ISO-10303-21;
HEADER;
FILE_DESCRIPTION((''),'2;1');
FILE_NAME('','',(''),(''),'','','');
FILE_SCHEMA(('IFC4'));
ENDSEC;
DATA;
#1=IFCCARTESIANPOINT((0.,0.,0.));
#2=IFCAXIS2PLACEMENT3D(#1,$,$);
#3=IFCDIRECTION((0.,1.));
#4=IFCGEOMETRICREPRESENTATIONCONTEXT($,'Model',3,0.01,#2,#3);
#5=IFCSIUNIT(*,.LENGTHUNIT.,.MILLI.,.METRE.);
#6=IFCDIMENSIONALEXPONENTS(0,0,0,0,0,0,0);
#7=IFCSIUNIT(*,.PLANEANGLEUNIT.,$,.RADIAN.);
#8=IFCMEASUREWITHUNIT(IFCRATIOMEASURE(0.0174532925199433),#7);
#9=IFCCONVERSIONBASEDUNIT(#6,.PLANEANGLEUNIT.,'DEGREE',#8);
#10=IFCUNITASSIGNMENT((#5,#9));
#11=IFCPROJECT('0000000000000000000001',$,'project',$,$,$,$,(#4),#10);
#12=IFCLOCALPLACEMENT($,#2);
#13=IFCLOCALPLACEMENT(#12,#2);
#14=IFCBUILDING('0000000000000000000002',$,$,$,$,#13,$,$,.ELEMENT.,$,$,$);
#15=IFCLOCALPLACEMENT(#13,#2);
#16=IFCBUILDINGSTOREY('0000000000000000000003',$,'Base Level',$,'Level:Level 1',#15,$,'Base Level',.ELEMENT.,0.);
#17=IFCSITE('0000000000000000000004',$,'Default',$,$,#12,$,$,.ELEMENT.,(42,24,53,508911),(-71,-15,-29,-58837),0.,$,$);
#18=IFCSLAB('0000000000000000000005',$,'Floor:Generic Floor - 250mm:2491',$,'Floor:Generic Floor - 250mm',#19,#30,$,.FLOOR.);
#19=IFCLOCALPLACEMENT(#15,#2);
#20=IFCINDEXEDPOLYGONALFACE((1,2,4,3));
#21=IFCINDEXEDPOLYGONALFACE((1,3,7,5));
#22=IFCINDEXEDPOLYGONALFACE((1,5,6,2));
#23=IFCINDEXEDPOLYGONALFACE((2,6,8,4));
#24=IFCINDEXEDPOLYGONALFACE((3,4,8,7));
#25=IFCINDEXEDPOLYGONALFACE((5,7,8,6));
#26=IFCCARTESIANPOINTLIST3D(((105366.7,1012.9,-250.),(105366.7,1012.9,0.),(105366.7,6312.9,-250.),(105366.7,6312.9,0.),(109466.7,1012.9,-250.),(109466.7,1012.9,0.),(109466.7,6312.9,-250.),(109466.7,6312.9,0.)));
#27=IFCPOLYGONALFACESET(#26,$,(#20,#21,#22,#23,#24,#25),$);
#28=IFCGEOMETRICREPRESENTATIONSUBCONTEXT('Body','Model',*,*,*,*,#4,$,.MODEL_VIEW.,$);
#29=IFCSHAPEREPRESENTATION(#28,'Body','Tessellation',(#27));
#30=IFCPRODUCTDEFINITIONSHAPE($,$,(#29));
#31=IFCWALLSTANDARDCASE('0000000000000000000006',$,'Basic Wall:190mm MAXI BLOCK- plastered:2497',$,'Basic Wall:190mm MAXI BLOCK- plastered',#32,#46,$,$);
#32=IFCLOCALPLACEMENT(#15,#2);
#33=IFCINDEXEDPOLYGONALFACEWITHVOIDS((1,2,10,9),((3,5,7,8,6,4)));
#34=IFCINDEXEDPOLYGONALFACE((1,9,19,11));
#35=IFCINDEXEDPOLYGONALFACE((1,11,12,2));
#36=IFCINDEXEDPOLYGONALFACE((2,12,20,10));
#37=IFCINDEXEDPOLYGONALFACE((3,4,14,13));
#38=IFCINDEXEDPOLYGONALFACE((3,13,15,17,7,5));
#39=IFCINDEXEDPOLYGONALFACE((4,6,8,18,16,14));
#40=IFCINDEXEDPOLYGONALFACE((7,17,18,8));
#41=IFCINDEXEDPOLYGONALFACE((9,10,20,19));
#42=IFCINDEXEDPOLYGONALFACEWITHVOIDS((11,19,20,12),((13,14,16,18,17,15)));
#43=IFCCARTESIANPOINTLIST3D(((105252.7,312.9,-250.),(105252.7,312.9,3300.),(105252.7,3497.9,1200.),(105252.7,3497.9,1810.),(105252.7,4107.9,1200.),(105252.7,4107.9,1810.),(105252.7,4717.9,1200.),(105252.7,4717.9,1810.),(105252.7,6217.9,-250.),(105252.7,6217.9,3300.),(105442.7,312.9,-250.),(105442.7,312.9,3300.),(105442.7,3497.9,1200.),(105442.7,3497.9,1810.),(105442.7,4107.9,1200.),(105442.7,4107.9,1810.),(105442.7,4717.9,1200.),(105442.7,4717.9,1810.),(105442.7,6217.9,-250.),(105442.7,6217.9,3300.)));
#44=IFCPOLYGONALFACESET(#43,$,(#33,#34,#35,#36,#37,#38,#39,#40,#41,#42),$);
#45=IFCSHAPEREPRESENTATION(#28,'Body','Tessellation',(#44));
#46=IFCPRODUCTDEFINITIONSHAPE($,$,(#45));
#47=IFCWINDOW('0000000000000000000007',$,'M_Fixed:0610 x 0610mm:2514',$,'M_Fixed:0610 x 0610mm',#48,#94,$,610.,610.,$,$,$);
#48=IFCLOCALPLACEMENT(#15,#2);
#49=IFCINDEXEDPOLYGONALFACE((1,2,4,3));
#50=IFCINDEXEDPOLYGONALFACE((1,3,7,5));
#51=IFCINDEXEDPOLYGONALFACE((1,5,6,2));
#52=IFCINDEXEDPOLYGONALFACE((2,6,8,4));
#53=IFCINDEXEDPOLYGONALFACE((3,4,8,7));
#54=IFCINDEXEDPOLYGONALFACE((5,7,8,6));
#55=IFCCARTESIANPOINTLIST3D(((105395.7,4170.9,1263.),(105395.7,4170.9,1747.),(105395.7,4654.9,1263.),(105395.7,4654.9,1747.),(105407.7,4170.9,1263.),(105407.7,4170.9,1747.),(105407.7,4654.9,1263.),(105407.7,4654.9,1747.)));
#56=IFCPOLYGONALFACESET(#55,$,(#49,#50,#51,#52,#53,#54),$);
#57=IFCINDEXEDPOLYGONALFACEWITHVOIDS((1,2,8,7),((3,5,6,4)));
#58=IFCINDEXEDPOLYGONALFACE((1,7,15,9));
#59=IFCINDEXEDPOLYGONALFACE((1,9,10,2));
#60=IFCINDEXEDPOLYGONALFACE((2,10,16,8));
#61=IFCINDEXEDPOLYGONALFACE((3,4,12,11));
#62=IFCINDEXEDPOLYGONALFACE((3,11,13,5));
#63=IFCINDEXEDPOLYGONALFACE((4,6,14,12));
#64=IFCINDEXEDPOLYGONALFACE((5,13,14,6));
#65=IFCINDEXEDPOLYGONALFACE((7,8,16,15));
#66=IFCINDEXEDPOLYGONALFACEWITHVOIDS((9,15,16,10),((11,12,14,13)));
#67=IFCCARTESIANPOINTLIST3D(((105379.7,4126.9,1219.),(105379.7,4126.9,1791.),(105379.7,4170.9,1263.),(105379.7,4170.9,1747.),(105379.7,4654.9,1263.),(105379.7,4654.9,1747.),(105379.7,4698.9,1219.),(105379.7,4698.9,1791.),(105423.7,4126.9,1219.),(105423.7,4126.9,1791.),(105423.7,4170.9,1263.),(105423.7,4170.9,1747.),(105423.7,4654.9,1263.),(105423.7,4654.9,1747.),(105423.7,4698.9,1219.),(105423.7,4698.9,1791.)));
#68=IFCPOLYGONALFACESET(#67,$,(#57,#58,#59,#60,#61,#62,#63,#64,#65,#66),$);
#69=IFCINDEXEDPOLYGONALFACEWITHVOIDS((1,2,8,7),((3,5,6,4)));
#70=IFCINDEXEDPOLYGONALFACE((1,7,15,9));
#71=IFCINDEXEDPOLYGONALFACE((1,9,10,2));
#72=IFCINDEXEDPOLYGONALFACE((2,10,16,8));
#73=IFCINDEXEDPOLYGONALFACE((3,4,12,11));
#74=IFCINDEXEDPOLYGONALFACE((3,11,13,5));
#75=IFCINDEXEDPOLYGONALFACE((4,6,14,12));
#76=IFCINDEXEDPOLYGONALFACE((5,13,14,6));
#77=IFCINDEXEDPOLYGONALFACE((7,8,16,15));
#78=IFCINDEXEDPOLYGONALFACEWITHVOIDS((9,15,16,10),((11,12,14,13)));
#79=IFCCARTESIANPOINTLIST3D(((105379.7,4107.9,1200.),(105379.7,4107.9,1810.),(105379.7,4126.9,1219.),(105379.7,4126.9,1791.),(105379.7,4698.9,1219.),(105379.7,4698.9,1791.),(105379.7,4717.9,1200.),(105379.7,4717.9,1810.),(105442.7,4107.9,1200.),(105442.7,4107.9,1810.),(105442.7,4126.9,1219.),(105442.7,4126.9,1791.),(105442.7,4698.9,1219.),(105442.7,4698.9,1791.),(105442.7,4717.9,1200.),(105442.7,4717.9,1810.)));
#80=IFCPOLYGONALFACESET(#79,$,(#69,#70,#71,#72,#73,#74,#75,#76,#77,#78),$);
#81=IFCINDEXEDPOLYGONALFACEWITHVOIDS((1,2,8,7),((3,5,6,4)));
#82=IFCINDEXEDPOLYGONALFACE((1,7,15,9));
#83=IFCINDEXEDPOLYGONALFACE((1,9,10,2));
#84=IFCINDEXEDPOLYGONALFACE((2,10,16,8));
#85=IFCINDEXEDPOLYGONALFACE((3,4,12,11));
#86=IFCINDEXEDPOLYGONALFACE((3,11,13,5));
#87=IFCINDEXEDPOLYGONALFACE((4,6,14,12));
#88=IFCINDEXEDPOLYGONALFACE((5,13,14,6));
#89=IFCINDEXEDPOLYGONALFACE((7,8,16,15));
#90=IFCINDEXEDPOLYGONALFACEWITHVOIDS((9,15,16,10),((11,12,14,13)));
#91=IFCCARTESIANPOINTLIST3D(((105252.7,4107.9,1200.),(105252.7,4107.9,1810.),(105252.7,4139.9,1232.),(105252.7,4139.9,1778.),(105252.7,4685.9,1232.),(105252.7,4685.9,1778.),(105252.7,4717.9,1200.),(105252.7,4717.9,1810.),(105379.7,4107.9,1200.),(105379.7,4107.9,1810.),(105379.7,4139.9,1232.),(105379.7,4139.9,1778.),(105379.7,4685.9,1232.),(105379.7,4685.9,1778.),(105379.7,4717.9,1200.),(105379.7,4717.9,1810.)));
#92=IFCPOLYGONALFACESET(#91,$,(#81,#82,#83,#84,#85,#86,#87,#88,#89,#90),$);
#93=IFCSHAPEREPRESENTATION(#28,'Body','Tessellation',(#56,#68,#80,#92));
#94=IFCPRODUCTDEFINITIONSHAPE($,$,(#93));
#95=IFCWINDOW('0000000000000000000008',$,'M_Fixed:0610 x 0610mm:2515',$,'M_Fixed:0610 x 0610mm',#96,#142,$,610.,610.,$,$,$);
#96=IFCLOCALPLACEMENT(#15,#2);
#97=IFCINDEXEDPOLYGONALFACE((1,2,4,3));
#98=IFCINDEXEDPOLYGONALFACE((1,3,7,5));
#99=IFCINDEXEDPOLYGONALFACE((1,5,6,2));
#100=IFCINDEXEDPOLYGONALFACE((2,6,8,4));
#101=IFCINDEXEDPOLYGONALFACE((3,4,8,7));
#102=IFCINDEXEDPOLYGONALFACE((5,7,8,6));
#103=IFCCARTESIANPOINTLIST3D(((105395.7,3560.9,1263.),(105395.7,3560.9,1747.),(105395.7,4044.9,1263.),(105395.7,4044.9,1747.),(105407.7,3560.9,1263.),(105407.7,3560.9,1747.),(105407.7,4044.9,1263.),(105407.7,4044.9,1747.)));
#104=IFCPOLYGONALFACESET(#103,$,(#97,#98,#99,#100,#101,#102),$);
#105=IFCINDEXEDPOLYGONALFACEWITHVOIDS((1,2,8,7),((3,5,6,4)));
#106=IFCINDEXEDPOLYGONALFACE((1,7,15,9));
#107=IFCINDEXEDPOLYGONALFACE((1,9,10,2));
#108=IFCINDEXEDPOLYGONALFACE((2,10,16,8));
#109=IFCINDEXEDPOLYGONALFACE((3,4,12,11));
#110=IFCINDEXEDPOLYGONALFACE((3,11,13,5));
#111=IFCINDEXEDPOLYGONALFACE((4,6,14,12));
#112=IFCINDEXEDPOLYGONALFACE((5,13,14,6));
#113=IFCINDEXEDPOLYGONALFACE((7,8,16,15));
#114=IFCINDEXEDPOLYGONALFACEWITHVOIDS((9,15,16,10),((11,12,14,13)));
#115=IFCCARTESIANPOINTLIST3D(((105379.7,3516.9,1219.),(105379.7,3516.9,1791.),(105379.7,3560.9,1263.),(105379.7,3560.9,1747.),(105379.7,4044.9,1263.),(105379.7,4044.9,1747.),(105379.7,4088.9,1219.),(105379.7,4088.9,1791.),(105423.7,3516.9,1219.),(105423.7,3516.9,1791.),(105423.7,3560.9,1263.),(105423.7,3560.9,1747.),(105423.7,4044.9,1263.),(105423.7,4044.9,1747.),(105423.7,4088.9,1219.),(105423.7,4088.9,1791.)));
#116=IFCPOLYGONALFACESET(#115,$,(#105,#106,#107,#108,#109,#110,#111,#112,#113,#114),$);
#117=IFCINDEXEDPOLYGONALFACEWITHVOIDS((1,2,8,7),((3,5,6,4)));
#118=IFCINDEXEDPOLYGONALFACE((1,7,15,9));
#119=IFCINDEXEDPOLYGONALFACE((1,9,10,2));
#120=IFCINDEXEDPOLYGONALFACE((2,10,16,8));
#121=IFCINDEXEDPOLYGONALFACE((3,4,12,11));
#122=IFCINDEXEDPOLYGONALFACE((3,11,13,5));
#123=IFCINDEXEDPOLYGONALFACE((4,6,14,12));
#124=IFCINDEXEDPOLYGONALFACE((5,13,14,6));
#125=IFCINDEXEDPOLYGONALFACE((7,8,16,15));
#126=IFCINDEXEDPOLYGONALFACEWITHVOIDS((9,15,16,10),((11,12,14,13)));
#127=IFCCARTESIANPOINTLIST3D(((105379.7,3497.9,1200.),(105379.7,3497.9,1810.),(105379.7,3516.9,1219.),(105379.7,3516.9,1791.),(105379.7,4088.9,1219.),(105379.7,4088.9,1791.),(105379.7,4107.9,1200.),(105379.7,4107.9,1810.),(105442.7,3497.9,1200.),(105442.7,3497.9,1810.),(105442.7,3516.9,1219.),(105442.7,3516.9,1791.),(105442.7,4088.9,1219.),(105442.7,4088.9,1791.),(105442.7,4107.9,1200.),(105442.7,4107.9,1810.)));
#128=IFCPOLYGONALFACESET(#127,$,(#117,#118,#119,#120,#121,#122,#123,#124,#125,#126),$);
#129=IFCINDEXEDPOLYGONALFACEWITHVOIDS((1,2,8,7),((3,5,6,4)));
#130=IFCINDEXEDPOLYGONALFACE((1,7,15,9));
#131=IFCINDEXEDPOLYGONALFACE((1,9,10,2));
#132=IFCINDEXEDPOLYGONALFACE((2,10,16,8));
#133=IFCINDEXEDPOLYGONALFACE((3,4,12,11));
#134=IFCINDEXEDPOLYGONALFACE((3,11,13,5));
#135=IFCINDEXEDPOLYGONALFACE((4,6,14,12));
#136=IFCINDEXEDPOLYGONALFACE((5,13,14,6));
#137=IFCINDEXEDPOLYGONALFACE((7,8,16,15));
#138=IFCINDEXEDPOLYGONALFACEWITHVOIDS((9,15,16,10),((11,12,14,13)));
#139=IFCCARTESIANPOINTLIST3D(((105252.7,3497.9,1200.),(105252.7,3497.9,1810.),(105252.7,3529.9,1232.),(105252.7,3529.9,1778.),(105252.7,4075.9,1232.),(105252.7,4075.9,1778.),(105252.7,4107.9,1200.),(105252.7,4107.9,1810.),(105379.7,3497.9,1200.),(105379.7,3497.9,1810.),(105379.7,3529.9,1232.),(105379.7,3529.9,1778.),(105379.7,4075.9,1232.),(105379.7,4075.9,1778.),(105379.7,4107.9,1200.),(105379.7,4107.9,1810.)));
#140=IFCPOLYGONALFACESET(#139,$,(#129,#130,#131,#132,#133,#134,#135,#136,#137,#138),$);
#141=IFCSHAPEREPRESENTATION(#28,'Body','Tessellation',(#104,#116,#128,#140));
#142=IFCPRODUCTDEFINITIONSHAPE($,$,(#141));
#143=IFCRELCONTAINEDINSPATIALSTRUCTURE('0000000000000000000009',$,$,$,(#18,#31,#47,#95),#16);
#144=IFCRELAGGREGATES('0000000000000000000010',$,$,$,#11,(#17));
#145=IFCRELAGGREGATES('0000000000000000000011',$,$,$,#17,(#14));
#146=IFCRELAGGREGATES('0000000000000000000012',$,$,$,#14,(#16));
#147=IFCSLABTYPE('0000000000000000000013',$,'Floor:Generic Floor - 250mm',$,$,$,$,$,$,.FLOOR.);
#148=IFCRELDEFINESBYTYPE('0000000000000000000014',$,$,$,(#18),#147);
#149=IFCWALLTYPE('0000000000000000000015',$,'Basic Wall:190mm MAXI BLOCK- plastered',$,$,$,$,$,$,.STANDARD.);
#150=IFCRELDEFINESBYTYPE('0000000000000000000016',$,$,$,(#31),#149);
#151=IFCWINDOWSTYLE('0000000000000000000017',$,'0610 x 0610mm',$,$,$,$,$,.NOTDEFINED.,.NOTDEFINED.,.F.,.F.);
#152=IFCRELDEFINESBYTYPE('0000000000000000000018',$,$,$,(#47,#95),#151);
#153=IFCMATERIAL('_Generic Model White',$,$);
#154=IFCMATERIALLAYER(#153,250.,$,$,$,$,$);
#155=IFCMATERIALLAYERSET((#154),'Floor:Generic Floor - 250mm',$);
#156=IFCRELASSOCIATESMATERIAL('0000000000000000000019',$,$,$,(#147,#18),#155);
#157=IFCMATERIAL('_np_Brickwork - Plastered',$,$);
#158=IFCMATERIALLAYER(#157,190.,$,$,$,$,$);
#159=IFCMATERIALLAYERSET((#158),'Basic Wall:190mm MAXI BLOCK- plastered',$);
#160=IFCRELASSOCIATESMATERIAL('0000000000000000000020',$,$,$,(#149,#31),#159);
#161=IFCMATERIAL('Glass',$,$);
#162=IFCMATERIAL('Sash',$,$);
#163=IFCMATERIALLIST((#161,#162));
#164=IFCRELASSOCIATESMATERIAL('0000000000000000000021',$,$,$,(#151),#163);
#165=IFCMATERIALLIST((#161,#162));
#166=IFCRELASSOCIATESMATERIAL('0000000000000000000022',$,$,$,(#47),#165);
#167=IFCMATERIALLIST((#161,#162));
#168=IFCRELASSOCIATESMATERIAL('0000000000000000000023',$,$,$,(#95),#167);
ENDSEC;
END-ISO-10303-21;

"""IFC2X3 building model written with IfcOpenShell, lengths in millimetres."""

from ifc_helpers import new_model, entity, si_unit, converted_unit, direction, frame, frame_2d, origin, origin_2d_with_axis, place, context, subcontext, project, spatial, polyline, rectangle, outline, extrude, source, transform, mapped, material, material_list, layer, layer_set, layer_usage, type_object, type_shapes, element, fill, save


model = new_model("IFC2X3")

# Units and contexts
model_context = context("Model", 3, precision=0.01, world=origin(), true_north=direction((0.0, 1.0)))
body_context = subcontext(model_context, "Body", "Model", "MODEL_VIEW")
ifc_project = project(units=[si_unit("LENGTHUNIT", "METRE", prefix="MILLI"), converted_unit("PLANEANGLEUNIT", "DEGREE", entity("IfcRatioMeasure", 0.0174532925199433), si_unit("PLANEANGLEUNIT", "RADIAN"), dimensions=[0, 0, 0, 0, 0, 0, 0])], contexts=[model_context])

# Site, building, storey
site_placement = place(None, origin())
site = spatial("IfcSite", under=ifc_project, at=site_placement, Name="Default", CompositionType="ELEMENT", RefLatitude=(42, 24, 53, 508911), RefLongitude=(-71, -15, -29, -58837), RefElevation=0.0)
building_placement = place(site_placement, origin())
building = spatial("IfcBuilding", under=site, at=building_placement, CompositionType="ELEMENT")
storey_placement = place(building_placement, origin())
storey = spatial("IfcBuildingStorey", under=building, at=storey_placement, Name="Base Level", ObjectType="Level:Level 1", LongName="Base Level", CompositionType="ELEMENT", Elevation=0.0)

# Slab
ifc_material_1 = material(Name="_Generic Model White")
ifc_layer_1 = layer(ifc_material_1, 250.0)
ifc_layer_set_1 = layer_set([ifc_layer_1], Name="Floor:Generic Floor - 250mm")
ifc_layer_usage_1 = layer_usage(ifc_layer_set_1, "AXIS3", "POSITIVE", 0.0)
slab_type = type_object("IfcSlabType", Name="Floor:Generic Floor - 250mm", PredefinedType="FLOOR", material=ifc_layer_set_1)
slab_placement = place(building_placement, origin())
element("IfcSlab", 1, at=slab_placement, inside=storey, type_object=slab_type, material=ifc_layer_usage_1, Name="Floor:Generic Floor - 250mm:2491", ObjectType="Floor:Generic Floor - 250mm", PredefinedType="FLOOR", context=body_context, shape_type="SweptSolid", body=[
    extrude(rectangle(XDim=5300.0, YDim=4100.0, at=origin_2d_with_axis()), frame((107416.7, 3662.9, 0.0), z_axis=(0.0, 0.0, -1.0), x_axis=(0.0, 1.0, 0.0)), (0.0, 0.0, 1.0), 250.0),
])

# Wall, openings, windows
ifc_material_2 = material(Name="_np_Brickwork - Plastered")
ifc_layer_2 = layer(ifc_material_2, 190.0)
ifc_layer_set_2 = layer_set([ifc_layer_2], Name="Basic Wall:190mm MAXI BLOCK- plastered")
ifc_layer_usage_2 = layer_usage(ifc_layer_set_2, "AXIS2", "NEGATIVE", 95.0)
wall_type = type_object("IfcWallType", Name="Basic Wall:190mm MAXI BLOCK- plastered", PredefinedType="STANDARD", material=ifc_layer_set_2)
wall_1_placement = place(building_placement, frame((105347.7, 312.9, -250.0), z_axis=(0.0, 0.0, 1.0), x_axis=(0.0, 1.0, 0.0)))
wall_1 = element("IfcWallStandardCase", 2, at=wall_1_placement, inside=storey, type_object=wall_type, material=ifc_layer_usage_2, Name="Basic Wall:190mm MAXI BLOCK- plastered:2497", ObjectType="Basic Wall:190mm MAXI BLOCK- plastered", context=body_context, shape_type="SweptSolid", body=[
    extrude(rectangle(XDim=5905.0, YDim=190.0, at=frame_2d((2952.5, 0.0), x_axis=(-1.0, 0.0))), origin(), (0.0, 0.0, 1.0), 3550.0),
])
opening_1_placement = place(wall_1_placement, frame((4405.0, 95.0, 1450.0)))
opening_1 = element("IfcOpeningElement", 3, at=opening_1_placement, cuts=wall_1, ObjectType="Opening", context=body_context, shape_type="SweptSolid", body=[
    extrude(rectangle(XDim=610.0, YDim=610.0, at=frame_2d((305.0, 305.0), x_axis=(1.0, 0.0))), frame((0.0, 0.0, 0.0), z_axis=(0.0, -1.0, 0.0), x_axis=(0.0, 0.0, 1.0)), (0.0, 0.0, 1.0), 190.0),
])
opening_2_placement = place(wall_1_placement, frame((3795.0, 95.0, 1450.0)))
opening_2 = element("IfcOpeningElement", 4, at=opening_2_placement, cuts=wall_1, ObjectType="Opening", context=body_context, shape_type="SweptSolid", body=[
    extrude(rectangle(XDim=610.0, YDim=610.0, at=frame_2d((305.0, 305.0), x_axis=(1.0, 0.0))), frame((0.0, 0.0, 0.0), z_axis=(0.0, -1.0, 0.0), x_axis=(0.0, 0.0, 1.0)), (0.0, 0.0, 1.0), 190.0),
])
ifc_material_3 = material(Name="Glass")
ifc_material_4 = material(Name="Sash")
ifc_material_list_1 = material_list([ifc_material_3, ifc_material_4])
ifc_material_list_2 = material_list([ifc_material_3, ifc_material_4])
window_style = type_object("IfcWindowStyle", Name="0610 x 0610mm", ConstructionType="NOTDEFINED", OperationType="NOTDEFINED", ParameterTakesPrecedence=False, Sizeable=False, material=ifc_material_list_2)
shared_shape_1 = source(origin(), body_context, "Body", "SweptSolid", [
    extrude(rectangle(XDim=12.0, YDim=484.0, at=frame_2d((0.0, 0.0), x_axis=(1.0, 0.0))), frame((305.0, 149.0, 63.0), z_axis=(0.0, 0.0, 1.0), x_axis=(0.0, -1.0, 0.0)), (0.0, 0.0, 1.0), 484.0),
    extrude(outline(polyline([(-286.0, -286.0), (286.0, -286.0), (286.0, 286.0), (-286.0, 286.0), (-286.0, -286.0)]), holes=[polyline([(-242.0, -242.0), (-242.0, 242.0), (242.0, 242.0), (242.0, -242.0), (-242.0, -242.0)])]), frame((305.0, 127.0, 305.0), z_axis=(0.0, 1.0, 0.0), x_axis=(1.0, 0.0, 0.0)), (0.0, 0.0, 1.0), 44.0),
    extrude(outline(polyline([(-305.0, -305.0), (305.0, -305.0), (305.0, 305.0), (-305.0, 305.0), (-305.0, -305.0)]), holes=[polyline([(-286.0, -286.0), (-286.0, 286.0), (286.0, 286.0), (286.0, -286.0), (-286.0, -286.0)])]), frame((305.0, 127.0, 305.0), z_axis=(0.0, 1.0, 0.0), x_axis=(1.0, 0.0, 0.0)), (0.0, 0.0, 1.0), 63.0),
    extrude(outline(polyline([(-305.0, -305.0), (305.0, -305.0), (305.0, 305.0), (-305.0, 305.0), (-305.0, -305.0)]), holes=[polyline([(-273.0, -273.0), (-273.0, 273.0), (273.0, 273.0), (273.0, -273.0), (-273.0, -273.0)])]), frame((305.0, 0.0, 305.0), z_axis=(0.0, 1.0, 0.0), x_axis=(1.0, 0.0, 0.0)), (0.0, 0.0, 1.0), 127.0),
])
type_shapes(window_style, [shared_shape_1])
window_1_placement = place(opening_1_placement, frame((0.0, 0.0, 0.0), z_axis=(0.0, 0.0, 1.0), x_axis=(-1.0, 0.0, 0.0)))
window_1 = element("IfcWindow", 5, at=window_1_placement, inside=storey, type_object=window_style, material=ifc_material_list_1, Name="M_Fixed:0610 x 0610mm:2514", ObjectType="M_Fixed:0610 x 0610mm", OverallHeight=610.0, OverallWidth=610.0, context=body_context, shape_type="MappedRepresentation", body=[
    mapped(shared_shape_1, transform((0.0, 0.0, 0.0), scale=1.0)),
])
fill(opening_1, window_1)
ifc_material_list_3 = material_list([ifc_material_3, ifc_material_4])
window_2_placement = place(opening_2_placement, frame((0.0, 0.0, 0.0), z_axis=(0.0, 0.0, 1.0), x_axis=(-1.0, 0.0, 0.0)))
window_2 = element("IfcWindow", 6, at=window_2_placement, inside=storey, type_object=window_style, material=ifc_material_list_3, Name="M_Fixed:0610 x 0610mm:2515", ObjectType="M_Fixed:0610 x 0610mm", OverallHeight=610.0, OverallWidth=610.0, context=body_context, shape_type="MappedRepresentation", body=[
    mapped(shared_shape_1, transform((0.0, 0.0, 0.0), scale=1.0)),
])
fill(opening_2, window_2)

save(model, "model.ifc")
